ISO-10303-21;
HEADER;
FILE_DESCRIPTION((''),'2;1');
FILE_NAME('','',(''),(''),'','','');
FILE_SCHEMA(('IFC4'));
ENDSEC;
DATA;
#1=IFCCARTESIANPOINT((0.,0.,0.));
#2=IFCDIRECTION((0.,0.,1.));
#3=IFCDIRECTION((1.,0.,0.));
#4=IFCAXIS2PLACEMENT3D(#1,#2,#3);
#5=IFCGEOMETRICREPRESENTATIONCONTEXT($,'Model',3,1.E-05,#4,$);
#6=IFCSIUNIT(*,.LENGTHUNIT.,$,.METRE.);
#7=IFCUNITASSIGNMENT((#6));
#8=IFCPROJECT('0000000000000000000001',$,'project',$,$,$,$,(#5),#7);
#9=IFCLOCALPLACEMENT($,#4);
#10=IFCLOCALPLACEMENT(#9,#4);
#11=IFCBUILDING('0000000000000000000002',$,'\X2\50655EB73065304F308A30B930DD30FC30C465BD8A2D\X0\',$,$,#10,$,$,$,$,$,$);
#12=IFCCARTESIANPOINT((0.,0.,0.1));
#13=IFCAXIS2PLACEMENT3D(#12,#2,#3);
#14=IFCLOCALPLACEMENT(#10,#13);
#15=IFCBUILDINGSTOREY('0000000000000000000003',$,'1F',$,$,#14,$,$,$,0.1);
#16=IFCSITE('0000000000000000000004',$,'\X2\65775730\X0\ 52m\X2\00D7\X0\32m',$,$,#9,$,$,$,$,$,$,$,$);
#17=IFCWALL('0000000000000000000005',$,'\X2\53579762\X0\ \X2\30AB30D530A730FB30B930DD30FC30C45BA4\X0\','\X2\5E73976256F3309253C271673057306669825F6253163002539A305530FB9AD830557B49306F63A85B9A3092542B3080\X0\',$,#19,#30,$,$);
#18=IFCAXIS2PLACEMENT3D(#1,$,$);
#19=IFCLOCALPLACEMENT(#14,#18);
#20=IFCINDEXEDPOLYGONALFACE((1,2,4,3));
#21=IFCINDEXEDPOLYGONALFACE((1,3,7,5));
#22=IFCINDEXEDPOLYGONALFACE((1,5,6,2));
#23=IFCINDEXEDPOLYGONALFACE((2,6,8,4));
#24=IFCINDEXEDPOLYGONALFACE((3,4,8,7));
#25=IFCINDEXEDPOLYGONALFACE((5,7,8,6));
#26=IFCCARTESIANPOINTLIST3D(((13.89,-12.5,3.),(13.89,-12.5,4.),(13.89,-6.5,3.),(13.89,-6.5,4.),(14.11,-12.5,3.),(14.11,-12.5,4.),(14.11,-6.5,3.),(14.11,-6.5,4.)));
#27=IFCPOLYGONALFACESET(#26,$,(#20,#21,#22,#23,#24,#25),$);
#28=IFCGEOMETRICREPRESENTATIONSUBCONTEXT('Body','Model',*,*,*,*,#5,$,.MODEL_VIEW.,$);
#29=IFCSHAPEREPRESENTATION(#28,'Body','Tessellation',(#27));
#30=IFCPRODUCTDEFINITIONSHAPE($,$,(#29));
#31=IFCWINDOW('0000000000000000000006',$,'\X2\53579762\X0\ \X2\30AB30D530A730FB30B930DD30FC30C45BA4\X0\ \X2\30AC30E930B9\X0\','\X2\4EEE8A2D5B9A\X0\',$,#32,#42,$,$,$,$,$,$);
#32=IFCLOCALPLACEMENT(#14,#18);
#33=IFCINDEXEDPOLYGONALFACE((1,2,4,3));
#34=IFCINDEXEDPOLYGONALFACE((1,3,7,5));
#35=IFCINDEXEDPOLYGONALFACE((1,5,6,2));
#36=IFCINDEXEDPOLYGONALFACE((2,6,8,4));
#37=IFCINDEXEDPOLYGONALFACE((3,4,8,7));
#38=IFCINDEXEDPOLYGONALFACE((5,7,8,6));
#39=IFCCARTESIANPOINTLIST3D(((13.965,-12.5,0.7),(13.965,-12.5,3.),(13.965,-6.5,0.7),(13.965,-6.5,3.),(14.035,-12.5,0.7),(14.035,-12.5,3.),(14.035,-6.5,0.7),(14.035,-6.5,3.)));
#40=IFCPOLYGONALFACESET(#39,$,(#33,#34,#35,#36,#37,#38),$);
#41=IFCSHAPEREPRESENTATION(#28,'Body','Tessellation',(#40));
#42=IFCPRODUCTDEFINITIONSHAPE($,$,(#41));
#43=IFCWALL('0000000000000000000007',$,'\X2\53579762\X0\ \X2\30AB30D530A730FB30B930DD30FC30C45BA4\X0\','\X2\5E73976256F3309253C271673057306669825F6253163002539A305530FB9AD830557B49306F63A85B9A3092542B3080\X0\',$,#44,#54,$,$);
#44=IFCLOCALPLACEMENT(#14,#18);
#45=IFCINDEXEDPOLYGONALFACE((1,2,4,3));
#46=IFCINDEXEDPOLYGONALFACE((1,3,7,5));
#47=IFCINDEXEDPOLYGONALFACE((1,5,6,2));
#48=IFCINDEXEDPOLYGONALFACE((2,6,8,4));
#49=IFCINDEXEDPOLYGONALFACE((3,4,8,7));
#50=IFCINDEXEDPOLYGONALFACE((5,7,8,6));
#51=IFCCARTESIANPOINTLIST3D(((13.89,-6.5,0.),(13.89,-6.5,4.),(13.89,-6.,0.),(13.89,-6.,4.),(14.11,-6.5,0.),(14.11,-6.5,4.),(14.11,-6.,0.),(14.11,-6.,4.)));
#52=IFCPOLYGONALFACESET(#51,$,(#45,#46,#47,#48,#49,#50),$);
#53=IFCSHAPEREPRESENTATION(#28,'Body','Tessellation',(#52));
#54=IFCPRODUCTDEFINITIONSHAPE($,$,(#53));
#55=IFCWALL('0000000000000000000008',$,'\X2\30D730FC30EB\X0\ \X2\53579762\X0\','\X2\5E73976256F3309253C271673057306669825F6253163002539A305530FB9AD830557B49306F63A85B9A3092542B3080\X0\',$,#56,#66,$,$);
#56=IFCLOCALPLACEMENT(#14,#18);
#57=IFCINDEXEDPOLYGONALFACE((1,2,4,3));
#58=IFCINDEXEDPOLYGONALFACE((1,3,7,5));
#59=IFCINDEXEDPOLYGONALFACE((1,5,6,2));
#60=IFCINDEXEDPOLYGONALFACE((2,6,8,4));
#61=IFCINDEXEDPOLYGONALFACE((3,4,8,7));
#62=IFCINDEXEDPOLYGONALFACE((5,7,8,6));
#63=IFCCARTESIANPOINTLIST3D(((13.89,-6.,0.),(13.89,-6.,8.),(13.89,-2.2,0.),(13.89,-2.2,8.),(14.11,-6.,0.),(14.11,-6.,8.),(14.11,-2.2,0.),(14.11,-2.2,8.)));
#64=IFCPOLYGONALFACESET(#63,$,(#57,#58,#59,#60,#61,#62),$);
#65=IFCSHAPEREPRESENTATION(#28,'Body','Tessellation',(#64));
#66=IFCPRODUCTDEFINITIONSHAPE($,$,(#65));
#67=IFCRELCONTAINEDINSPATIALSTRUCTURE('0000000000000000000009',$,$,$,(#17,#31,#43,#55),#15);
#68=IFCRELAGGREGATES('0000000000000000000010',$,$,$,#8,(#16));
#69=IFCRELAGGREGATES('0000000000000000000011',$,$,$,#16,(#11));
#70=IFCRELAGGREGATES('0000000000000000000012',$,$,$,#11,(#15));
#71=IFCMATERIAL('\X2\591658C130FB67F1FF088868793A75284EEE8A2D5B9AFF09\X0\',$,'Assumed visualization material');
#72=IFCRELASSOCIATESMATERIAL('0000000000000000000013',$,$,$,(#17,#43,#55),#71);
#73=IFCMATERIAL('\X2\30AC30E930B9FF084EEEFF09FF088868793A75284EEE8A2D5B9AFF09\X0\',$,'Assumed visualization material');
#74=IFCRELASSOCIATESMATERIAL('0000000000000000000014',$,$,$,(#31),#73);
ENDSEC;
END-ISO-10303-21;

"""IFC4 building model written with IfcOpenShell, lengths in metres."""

from ifc_helpers import new_model, si_unit, frame, origin_with_axes, place, context, subcontext, project, spatial, rectangle, extrude, material, element, save


model = new_model("IFC4")

# Units and contexts
model_context = context("Model", 3, precision=1e-05, world=origin_with_axes())
body_context = subcontext(model_context, "Body", "Model", "MODEL_VIEW")
ifc_project = project(units=[si_unit("LENGTHUNIT", "METRE")], contexts=[model_context])

# Site, building, storey
site_placement = place(None, origin_with_axes())
site = spatial("IfcSite", under=ifc_project, at=site_placement, Name="敷地 52m×32m")
building_placement = place(site_placement, origin_with_axes())
building = spatial("IfcBuilding", under=site, at=building_placement, Name="健康づくりスポーツ施設")
storey_placement = place(building_placement, frame((0.0, 0.0, 0.1), z_axis=(0.0, 0.0, 1.0), x_axis=(1.0, 0.0, 0.0)))
storey = spatial("IfcBuildingStorey", under=building, at=storey_placement, Name="1F", Elevation=0.1)

# Shared definitions
ifc_material_1 = material(Name="外壁・柱（表示用仮設定）", Category="Assumed visualization material")

# Wall
wall_1_placement = place(storey_placement, frame((14.0, -9.5, 3.0), z_axis=(0.0, 0.0, 1.0), x_axis=(1.0, 0.0, 0.0)))
element("IfcWall", 1, at=wall_1_placement, inside=storey, material=ifc_material_1, Name="南面 カフェ・スポーツ室", Description="平面図を参照して概形化。厚さ・高さ等は推定を含む", context=body_context, shape_type="SweptSolid", body=[
    extrude(rectangle(XDim=0.22, YDim=6.0), origin_with_axes(), (0.0, 0.0, 1.0), 1.0),
])

# Window
ifc_material_2 = material(Name="ガラス（仮）（表示用仮設定）", Category="Assumed visualization material")
window_placement = place(storey_placement, frame((14.0, -9.5, 0.7), z_axis=(0.0, 0.0, 1.0), x_axis=(1.0, 0.0, 0.0)))
element("IfcWindow", 2, at=window_placement, inside=storey, material=ifc_material_2, Name="南面 カフェ・スポーツ室 ガラス", Description="仮設定", context=body_context, shape_type="SweptSolid", body=[
    extrude(rectangle(XDim=0.07, YDim=6.0), origin_with_axes(), (0.0, 0.0, 1.0), 2.3),
])

# Walls
wall_2_placement = place(storey_placement, frame((14.0, -6.25, 0.0), z_axis=(0.0, 0.0, 1.0), x_axis=(1.0, 0.0, 0.0)))
element("IfcWall", 3, at=wall_2_placement, inside=storey, material=ifc_material_1, Name="南面 カフェ・スポーツ室", Description="平面図を参照して概形化。厚さ・高さ等は推定を含む", context=body_context, shape_type="SweptSolid", body=[
    extrude(rectangle(XDim=0.22, YDim=0.5), origin_with_axes(), (0.0, 0.0, 1.0), 4.0),
])
wall_3_placement = place(storey_placement, frame((14.0, -4.1, 0.0), z_axis=(0.0, 0.0, 1.0), x_axis=(1.0, 0.0, 0.0)))
element("IfcWall", 4, at=wall_3_placement, inside=storey, material=ifc_material_1, Name="プール 南面", Description="平面図を参照して概形化。厚さ・高さ等は推定を含む", context=body_context, shape_type="SweptSolid", body=[
    extrude(rectangle(XDim=0.22, YDim=3.8), origin_with_axes(), (0.0, 0.0, 1.0), 8.0),
])

save(model, "model.ifc")
